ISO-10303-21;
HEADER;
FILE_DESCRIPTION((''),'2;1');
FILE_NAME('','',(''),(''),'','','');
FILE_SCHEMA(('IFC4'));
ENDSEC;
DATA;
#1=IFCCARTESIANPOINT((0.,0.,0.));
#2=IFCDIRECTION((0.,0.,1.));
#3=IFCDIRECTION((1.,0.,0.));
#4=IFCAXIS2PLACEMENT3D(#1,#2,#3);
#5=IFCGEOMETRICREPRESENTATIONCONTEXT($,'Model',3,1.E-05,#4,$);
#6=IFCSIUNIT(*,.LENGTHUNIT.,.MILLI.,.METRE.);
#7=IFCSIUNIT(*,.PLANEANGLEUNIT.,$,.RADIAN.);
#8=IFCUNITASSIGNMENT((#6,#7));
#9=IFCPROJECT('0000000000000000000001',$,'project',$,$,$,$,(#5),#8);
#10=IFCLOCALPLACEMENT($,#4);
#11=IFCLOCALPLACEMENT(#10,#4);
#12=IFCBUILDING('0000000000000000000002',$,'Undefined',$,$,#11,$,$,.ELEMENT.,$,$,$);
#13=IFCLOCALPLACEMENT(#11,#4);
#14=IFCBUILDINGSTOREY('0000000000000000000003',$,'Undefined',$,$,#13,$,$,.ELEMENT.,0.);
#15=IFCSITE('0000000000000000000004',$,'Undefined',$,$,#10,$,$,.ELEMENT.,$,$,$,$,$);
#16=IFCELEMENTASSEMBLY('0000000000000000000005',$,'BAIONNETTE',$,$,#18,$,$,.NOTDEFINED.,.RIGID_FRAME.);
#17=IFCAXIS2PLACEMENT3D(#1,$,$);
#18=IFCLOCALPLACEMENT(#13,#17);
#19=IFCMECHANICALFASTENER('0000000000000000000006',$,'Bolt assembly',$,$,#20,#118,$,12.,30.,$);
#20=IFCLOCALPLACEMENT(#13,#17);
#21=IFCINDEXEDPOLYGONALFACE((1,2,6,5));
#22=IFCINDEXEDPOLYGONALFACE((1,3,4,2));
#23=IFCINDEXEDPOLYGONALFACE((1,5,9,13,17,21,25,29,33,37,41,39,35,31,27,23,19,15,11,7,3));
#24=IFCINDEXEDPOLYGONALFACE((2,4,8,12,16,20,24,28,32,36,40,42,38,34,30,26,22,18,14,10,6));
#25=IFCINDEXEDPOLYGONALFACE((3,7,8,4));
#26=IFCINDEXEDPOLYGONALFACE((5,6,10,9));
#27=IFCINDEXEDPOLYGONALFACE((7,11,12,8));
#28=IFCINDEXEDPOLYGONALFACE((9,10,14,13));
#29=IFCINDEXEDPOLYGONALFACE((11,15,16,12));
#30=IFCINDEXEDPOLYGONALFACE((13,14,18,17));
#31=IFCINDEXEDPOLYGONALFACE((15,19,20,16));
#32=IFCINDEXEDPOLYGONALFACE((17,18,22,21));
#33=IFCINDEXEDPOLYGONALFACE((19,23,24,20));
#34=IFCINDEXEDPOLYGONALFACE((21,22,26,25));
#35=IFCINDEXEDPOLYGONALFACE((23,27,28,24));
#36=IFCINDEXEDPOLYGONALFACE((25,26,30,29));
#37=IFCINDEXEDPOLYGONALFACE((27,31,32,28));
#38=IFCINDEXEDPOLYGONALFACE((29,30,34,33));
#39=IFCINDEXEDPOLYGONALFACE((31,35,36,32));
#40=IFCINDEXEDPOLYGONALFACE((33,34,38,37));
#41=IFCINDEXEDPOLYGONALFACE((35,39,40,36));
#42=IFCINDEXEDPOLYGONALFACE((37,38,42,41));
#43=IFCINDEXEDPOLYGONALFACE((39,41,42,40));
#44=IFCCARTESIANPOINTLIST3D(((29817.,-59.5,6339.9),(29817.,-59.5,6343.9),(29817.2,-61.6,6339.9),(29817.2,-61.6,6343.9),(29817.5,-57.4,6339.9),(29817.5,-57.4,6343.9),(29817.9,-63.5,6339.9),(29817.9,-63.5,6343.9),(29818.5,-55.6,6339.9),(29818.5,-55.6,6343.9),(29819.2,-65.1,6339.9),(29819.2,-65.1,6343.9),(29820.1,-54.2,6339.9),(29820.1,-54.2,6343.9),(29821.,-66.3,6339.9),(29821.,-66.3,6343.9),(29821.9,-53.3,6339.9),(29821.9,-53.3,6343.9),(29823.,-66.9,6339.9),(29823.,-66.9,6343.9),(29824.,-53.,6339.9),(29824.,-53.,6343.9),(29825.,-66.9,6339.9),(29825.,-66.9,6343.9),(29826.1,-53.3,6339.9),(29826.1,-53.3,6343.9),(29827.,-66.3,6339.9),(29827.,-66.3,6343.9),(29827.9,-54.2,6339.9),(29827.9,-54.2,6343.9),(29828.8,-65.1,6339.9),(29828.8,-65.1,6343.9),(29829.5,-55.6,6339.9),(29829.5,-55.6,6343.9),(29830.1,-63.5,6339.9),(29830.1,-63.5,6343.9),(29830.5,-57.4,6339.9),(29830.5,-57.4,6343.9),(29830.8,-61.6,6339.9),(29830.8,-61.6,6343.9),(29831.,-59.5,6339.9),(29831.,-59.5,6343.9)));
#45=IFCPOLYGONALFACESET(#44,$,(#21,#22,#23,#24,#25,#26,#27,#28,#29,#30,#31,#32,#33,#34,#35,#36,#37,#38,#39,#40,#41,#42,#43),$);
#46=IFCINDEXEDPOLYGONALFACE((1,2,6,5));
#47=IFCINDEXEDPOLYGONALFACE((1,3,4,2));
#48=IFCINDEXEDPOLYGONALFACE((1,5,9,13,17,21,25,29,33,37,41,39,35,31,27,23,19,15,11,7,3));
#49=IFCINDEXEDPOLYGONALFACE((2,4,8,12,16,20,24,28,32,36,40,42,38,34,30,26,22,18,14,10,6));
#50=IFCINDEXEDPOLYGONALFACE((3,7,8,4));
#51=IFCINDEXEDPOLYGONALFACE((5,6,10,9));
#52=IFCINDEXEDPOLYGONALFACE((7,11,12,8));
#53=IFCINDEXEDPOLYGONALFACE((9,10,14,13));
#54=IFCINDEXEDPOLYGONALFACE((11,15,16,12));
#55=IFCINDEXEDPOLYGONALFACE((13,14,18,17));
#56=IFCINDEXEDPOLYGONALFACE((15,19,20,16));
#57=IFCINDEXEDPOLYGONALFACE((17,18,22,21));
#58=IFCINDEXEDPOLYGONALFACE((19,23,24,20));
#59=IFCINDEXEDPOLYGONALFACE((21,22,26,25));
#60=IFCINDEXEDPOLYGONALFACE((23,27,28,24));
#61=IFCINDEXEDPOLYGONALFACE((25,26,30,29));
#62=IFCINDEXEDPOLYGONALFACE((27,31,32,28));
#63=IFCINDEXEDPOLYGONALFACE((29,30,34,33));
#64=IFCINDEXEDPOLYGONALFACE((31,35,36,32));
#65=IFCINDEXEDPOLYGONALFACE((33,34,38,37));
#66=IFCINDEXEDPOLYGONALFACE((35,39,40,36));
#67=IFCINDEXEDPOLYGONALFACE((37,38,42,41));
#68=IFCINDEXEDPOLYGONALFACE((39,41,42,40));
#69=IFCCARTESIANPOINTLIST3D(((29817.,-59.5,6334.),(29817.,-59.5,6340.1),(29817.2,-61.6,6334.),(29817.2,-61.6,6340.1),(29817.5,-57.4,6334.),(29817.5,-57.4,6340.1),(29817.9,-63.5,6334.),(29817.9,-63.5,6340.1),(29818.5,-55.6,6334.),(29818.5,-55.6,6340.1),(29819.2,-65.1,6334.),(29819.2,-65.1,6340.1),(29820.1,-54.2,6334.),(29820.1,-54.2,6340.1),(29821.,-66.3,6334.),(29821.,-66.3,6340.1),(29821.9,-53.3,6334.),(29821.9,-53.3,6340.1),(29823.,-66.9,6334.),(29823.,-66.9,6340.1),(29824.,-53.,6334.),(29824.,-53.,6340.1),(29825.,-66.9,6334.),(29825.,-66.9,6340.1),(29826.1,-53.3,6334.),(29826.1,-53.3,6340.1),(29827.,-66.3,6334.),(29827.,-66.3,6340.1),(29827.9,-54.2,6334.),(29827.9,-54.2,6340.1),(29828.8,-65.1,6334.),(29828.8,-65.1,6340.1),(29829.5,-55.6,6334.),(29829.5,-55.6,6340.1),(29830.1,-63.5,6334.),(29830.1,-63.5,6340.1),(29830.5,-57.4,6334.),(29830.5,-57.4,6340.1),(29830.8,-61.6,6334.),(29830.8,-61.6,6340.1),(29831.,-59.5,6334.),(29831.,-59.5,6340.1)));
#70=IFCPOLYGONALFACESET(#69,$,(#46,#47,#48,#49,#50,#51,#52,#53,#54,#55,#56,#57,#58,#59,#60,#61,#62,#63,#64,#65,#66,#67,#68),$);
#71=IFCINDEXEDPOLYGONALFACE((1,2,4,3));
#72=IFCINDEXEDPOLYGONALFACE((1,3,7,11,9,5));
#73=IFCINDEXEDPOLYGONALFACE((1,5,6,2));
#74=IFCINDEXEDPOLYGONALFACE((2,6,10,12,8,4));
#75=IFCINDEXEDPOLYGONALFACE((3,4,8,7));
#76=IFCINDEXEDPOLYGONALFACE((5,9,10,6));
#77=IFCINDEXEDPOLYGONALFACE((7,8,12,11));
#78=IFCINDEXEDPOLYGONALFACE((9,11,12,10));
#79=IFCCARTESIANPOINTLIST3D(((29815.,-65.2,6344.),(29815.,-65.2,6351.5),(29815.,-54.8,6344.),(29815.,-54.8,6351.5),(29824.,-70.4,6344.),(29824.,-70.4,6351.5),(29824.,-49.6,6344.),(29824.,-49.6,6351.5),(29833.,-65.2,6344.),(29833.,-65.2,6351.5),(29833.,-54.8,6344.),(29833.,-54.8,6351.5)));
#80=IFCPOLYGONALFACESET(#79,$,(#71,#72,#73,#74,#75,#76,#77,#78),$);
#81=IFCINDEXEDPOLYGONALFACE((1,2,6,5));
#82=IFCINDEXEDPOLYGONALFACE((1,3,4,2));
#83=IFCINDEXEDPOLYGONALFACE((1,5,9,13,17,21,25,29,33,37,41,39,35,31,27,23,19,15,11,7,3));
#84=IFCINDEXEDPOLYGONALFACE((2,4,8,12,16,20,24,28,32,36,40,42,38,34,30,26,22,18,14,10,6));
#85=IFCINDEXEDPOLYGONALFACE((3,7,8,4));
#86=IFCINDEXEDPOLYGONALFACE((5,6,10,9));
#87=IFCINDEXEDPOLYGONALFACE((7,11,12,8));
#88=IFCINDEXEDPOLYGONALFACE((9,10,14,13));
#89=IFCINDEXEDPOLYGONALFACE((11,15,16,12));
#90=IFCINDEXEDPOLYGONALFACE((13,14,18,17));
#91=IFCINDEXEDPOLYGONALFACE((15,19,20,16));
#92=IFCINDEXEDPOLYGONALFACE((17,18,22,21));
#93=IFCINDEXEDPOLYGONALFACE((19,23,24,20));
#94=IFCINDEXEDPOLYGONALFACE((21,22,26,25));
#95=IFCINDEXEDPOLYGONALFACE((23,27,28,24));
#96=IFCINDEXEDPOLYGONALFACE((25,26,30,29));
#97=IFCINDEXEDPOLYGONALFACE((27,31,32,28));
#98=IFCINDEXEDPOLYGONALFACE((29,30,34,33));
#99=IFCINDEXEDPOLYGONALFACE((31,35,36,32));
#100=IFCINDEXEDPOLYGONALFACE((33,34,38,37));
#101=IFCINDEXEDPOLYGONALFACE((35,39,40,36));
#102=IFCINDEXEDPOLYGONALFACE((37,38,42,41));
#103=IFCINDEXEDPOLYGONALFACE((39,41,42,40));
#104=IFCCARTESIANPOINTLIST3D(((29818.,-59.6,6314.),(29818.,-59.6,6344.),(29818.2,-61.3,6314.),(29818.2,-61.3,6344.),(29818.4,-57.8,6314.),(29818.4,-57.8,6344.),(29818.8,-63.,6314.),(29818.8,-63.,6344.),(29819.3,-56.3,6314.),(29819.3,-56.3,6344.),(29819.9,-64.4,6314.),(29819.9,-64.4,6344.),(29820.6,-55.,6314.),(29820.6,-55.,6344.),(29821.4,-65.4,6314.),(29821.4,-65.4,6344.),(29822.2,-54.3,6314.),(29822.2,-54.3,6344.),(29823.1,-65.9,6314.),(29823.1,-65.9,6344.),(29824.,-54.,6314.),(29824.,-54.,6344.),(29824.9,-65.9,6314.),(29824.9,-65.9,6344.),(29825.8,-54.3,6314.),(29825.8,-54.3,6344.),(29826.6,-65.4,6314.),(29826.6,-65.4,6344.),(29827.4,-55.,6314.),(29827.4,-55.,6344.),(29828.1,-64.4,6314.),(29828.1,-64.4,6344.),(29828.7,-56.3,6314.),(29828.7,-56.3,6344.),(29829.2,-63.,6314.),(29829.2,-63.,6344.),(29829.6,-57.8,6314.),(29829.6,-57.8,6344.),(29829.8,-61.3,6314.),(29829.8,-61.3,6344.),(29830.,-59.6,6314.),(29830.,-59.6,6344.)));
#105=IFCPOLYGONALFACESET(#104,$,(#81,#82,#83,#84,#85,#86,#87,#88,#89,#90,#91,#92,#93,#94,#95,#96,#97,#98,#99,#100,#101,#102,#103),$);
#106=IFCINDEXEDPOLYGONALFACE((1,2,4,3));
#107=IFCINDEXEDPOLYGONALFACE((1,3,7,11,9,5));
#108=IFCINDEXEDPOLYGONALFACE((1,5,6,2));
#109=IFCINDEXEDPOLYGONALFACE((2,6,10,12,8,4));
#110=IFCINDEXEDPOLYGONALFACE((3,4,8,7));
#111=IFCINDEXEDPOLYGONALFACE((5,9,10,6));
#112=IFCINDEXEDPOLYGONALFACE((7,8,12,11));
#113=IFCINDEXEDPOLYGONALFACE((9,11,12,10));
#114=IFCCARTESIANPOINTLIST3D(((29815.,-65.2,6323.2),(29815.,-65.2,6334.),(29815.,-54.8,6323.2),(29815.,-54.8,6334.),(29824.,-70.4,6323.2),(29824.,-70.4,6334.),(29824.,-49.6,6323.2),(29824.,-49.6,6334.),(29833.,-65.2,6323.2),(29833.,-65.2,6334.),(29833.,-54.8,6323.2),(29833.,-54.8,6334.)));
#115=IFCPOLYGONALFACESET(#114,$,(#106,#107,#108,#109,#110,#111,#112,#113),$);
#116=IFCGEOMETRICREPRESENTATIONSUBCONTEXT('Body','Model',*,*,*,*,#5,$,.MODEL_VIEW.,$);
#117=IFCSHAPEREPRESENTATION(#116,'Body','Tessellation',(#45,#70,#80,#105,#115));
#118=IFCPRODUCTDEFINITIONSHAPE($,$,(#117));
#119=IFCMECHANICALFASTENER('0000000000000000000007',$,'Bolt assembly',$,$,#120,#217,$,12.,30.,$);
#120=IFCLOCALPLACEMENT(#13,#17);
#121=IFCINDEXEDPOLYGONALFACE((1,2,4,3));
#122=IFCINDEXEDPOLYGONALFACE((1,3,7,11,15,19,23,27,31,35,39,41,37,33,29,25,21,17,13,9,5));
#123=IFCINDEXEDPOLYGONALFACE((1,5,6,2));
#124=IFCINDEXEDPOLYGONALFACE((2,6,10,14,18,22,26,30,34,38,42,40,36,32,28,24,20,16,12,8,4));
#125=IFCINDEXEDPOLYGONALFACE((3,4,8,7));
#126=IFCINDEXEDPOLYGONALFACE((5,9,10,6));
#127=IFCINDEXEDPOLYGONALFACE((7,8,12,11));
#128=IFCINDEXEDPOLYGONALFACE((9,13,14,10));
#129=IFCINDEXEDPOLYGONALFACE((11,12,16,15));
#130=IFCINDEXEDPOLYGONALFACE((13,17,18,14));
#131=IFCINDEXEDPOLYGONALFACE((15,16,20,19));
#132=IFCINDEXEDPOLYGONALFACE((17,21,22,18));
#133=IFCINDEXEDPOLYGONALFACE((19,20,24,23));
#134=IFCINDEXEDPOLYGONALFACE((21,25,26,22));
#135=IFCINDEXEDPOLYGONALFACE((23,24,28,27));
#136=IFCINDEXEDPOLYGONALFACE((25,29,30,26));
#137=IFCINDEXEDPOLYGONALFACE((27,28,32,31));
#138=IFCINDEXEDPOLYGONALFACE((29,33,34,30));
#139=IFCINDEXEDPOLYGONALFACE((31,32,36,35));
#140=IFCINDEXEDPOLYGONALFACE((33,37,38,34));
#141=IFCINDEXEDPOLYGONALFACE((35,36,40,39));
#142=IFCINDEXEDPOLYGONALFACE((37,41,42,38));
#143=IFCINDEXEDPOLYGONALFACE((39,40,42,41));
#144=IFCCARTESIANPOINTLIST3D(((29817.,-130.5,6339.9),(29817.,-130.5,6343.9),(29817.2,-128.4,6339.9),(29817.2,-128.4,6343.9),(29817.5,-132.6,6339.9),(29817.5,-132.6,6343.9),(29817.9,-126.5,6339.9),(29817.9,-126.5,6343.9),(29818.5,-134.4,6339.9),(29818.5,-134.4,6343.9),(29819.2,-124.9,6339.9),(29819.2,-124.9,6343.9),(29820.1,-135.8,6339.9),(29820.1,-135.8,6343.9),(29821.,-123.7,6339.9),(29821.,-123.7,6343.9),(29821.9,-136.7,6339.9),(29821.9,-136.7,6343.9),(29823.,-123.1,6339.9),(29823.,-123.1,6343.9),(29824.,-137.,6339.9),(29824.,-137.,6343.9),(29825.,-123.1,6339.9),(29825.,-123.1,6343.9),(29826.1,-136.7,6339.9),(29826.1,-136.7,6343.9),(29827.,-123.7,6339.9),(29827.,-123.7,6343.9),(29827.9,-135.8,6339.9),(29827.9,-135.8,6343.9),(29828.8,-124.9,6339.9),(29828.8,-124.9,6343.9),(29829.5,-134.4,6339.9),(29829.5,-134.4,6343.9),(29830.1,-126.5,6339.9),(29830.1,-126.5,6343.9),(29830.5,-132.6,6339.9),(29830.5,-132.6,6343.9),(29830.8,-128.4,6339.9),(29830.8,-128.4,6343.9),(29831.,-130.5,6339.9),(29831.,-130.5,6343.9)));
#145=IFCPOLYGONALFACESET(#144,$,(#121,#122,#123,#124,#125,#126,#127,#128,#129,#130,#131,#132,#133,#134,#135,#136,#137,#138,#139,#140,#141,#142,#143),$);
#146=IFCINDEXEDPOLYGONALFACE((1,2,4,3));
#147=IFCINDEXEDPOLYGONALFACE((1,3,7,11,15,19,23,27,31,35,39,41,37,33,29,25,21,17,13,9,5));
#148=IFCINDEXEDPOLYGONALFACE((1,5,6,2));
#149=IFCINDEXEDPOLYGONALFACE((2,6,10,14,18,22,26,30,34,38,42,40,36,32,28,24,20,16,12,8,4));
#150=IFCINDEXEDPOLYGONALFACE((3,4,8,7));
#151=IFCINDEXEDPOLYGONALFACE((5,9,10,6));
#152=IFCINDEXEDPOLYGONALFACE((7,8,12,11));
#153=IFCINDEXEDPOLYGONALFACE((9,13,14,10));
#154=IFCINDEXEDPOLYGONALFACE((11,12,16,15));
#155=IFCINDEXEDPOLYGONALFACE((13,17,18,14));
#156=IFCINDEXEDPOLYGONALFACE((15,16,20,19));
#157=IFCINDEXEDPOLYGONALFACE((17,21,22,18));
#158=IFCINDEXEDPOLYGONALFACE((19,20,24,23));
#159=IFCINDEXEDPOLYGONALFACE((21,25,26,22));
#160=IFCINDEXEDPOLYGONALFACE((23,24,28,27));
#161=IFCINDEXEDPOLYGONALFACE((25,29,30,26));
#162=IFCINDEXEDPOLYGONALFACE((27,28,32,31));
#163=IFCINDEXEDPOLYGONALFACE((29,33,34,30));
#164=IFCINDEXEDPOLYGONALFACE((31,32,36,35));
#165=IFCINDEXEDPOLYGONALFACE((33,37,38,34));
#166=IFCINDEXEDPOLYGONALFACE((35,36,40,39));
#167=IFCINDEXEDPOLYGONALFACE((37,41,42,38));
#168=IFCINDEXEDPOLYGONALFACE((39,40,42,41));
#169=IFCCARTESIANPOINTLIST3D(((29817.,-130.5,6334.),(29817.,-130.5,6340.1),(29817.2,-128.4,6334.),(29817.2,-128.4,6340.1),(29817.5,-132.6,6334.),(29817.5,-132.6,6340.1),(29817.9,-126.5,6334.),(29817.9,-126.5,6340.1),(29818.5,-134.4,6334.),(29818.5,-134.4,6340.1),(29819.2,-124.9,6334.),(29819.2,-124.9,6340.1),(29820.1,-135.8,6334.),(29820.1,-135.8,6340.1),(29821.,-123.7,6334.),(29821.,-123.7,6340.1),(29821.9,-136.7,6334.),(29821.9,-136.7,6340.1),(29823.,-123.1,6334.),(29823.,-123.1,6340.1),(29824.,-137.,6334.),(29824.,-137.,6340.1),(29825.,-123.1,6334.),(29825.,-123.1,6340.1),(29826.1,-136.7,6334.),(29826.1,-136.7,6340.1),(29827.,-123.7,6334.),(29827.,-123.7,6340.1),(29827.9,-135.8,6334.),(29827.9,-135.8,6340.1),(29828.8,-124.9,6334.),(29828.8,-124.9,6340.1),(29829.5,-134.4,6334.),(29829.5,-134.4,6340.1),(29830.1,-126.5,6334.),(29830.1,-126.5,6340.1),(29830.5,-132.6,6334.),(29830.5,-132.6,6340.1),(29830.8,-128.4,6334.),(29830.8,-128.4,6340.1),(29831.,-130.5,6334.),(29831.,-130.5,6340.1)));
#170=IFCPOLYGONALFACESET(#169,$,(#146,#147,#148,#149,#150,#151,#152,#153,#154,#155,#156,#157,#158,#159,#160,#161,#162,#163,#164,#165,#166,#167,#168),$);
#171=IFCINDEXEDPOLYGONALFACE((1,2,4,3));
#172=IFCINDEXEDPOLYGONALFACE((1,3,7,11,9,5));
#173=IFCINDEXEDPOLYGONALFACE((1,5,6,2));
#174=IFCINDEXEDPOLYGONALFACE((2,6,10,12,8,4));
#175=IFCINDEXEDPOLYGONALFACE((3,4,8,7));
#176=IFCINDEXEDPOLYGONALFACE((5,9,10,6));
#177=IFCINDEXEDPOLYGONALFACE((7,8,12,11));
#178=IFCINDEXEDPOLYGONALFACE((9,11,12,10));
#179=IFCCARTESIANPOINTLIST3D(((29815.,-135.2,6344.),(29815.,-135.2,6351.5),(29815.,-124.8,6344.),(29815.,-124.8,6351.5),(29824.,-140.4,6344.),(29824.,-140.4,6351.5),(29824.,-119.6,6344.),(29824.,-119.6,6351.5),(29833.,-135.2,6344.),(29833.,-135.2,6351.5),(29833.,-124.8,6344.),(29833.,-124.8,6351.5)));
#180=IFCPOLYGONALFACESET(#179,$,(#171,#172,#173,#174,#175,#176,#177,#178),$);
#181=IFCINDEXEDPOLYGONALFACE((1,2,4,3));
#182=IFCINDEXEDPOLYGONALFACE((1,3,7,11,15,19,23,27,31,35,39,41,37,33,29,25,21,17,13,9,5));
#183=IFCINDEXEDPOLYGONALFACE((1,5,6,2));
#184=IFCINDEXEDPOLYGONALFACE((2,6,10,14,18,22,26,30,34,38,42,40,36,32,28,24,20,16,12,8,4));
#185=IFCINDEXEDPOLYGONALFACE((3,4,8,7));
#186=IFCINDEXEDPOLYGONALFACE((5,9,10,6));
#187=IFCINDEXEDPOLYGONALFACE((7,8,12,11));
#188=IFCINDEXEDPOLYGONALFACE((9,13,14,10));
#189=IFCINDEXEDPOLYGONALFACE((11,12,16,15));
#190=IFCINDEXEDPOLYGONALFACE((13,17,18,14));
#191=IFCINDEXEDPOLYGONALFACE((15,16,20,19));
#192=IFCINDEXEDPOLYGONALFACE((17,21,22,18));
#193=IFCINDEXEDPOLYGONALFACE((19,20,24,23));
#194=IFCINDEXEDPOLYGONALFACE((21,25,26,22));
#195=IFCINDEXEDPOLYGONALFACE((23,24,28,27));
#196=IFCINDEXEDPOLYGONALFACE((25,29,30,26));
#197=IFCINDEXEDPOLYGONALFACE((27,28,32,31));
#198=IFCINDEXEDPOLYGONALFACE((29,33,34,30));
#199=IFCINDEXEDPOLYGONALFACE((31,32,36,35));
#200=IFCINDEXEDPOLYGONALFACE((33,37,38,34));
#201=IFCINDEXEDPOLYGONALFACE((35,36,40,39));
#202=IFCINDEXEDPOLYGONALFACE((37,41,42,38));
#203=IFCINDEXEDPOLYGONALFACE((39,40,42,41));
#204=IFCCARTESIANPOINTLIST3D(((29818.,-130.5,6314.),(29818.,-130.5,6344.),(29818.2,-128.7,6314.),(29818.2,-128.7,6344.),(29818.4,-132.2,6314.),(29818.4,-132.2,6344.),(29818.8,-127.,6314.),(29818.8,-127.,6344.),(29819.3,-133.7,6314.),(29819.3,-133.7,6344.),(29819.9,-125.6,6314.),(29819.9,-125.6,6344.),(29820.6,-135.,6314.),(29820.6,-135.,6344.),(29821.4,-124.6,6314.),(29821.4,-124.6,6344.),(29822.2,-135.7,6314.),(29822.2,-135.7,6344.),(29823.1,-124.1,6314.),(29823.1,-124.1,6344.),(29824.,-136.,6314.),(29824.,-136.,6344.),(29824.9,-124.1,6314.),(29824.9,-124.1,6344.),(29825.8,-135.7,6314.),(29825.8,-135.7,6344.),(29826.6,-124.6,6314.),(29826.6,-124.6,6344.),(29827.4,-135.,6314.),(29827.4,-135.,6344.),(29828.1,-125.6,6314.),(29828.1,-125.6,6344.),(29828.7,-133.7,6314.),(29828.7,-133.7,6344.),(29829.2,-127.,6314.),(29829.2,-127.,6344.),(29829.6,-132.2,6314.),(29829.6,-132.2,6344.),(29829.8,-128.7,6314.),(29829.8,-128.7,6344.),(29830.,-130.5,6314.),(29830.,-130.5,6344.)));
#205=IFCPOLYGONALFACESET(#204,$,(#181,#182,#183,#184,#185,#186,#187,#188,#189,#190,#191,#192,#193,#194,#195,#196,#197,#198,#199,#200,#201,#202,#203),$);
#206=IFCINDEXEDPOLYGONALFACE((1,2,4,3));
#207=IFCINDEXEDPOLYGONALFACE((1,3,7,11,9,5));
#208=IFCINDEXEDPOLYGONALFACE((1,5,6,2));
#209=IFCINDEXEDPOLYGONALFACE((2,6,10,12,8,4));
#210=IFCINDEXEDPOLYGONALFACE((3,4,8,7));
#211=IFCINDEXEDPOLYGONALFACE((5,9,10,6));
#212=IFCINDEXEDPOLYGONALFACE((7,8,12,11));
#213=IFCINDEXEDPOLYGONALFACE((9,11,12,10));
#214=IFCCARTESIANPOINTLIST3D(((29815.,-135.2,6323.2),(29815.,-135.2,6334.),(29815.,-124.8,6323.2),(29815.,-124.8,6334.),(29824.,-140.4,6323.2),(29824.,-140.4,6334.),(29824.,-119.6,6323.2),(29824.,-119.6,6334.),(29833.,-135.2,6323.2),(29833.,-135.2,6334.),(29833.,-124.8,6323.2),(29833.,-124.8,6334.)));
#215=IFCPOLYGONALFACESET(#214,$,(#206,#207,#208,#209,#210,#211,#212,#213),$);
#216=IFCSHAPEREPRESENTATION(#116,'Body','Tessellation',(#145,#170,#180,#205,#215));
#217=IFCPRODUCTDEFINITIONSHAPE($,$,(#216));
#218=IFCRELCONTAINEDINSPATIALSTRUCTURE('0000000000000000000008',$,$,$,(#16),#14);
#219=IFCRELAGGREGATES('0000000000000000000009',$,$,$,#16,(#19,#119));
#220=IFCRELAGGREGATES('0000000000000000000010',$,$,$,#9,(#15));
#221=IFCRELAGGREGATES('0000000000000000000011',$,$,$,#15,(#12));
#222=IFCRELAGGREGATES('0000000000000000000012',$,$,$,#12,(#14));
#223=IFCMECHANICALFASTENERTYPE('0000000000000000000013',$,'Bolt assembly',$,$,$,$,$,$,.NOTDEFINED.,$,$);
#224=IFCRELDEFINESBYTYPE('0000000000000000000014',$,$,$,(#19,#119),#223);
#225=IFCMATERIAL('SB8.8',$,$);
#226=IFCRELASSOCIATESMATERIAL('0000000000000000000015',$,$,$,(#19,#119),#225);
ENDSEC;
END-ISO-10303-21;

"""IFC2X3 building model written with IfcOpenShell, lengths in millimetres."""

from ifc_helpers import new_model, si_unit, frame, origin_with_axes, origin_2d_with_axis, place, context, subcontext, project, spatial, polyline, circle, outline, extrude, source, transform, mapped, material, type_object, element, aggregate, save


model = new_model("IFC2X3")

# Units and contexts
model_context = context("Model", 3, precision=1e-05, world=origin_with_axes())
body_context = subcontext(model_context, "Body", "Model", "MODEL_VIEW")
ifc_project = project(units=[si_unit("LENGTHUNIT", "METRE", prefix="MILLI"), si_unit("PLANEANGLEUNIT", "RADIAN")], contexts=[model_context])

# Site, building, storey
site_placement = place(None, origin_with_axes())
site = spatial("IfcSite", under=ifc_project, at=site_placement, Name="Undefined", CompositionType="ELEMENT")
building_placement = place(site_placement, origin_with_axes())
building = spatial("IfcBuilding", under=site, at=building_placement, Name="Undefined", CompositionType="ELEMENT")
storey_placement = place(building_placement, origin_with_axes())
storey = spatial("IfcBuildingStorey", under=building, at=storey_placement, Name="Undefined", CompositionType="ELEMENT", Elevation=0.0)

# Element assembly
assembly_1_placement = place(storey_placement, origin_with_axes())
assembly_1 = element("IfcElementAssembly", 1, at=assembly_1_placement, inside=storey, Name="BAIONNETTE", AssemblyPlace="NOTDEFINED", PredefinedType="RIGID_FRAME")

# Mechanical fasteners
ifc_material_1 = material(Name="SB8.8")
mechanical_fastener_type = type_object("IfcMechanicalFastenerType", Name="Bolt assembly")
shared_shape_1 = source(origin_with_axes(), body_context, "Body", "SweptSolid", [
    extrude(circle(Radius=7.0, at=origin_2d_with_axis()), frame((0.0, -3.9, 0.0), z_axis=(0.0, 1.0, 0.0), x_axis=(1.0, 0.0, 0.0)), (0.0, 0.0, 1.0), 4.0),
    extrude(circle(Radius=7.0, at=origin_2d_with_axis()), frame((0.0, -0.1, 0.0), z_axis=(0.0, 1.0, 0.0), x_axis=(1.0, 0.0, 0.0)), (0.0, 0.0, 1.0), 6.1),
    extrude(outline(polyline([(10.4, 0.0), (5.2, 9.0), (-5.2, 9.0), (-10.4, 0.0), (-5.2, -9.0), (5.2, -9.0), (10.4, 0.0)])), frame((0.0, -11.5, 0.0), z_axis=(0.0, 1.0, 0.0), x_axis=(1.0, 0.0, 0.0)), (0.0, 0.0, 1.0), 7.5),
    extrude(circle(Radius=6.0, at=origin_2d_with_axis()), frame((0.0, -4.0, 0.0), z_axis=(0.0, 1.0, 0.0), x_axis=(1.0, 0.0, 0.0)), (0.0, 0.0, 1.0), 30.0),
    extrude(outline(polyline([(10.4, 0.0), (5.2, 9.0), (-5.2, 9.0), (-10.4, 0.0), (-5.2, -9.0), (5.2, -9.0), (10.4, 0.0)])), frame((0.0, 6.0, 0.0), z_axis=(0.0, 1.0, 0.0), x_axis=(1.0, 0.0, 0.0)), (0.0, 0.0, 1.0), 10.8),
])
mechanical_fastener_1_placement = place(assembly_1_placement, frame((29824.0, -60.0, 6340.0), z_axis=(-1.0, 0.0, 0.0), x_axis=(0.0, 1.0, 0.0)))
mechanical_fastener_1 = element("IfcMechanicalFastener", 2, at=mechanical_fastener_1_placement, type_object=mechanical_fastener_type, material=ifc_material_1, Name="Bolt assembly", NominalDiameter=12.0, NominalLength=30.0, context=body_context, shape_type="MappedRepresentation", body=[
    mapped(shared_shape_1, transform((0.0, 0.0, 0.0))),
])
mechanical_fastener_2_placement = place(assembly_1_placement, frame((29824.0, -130.0, 6340.0), z_axis=(1.0, 0.0, 0.0), x_axis=(0.0, -1.0, 0.0)))
mechanical_fastener_2 = element("IfcMechanicalFastener", 3, at=mechanical_fastener_2_placement, type_object=mechanical_fastener_type, material=ifc_material_1, Name="Bolt assembly", NominalDiameter=12.0, NominalLength=30.0, context=body_context, shape_type="MappedRepresentation", body=[
    mapped(shared_shape_1, transform((0.0, 0.0, 0.0))),
])

aggregate(assembly_1, [mechanical_fastener_1, mechanical_fastener_2])

save(model, "model.ifc")
